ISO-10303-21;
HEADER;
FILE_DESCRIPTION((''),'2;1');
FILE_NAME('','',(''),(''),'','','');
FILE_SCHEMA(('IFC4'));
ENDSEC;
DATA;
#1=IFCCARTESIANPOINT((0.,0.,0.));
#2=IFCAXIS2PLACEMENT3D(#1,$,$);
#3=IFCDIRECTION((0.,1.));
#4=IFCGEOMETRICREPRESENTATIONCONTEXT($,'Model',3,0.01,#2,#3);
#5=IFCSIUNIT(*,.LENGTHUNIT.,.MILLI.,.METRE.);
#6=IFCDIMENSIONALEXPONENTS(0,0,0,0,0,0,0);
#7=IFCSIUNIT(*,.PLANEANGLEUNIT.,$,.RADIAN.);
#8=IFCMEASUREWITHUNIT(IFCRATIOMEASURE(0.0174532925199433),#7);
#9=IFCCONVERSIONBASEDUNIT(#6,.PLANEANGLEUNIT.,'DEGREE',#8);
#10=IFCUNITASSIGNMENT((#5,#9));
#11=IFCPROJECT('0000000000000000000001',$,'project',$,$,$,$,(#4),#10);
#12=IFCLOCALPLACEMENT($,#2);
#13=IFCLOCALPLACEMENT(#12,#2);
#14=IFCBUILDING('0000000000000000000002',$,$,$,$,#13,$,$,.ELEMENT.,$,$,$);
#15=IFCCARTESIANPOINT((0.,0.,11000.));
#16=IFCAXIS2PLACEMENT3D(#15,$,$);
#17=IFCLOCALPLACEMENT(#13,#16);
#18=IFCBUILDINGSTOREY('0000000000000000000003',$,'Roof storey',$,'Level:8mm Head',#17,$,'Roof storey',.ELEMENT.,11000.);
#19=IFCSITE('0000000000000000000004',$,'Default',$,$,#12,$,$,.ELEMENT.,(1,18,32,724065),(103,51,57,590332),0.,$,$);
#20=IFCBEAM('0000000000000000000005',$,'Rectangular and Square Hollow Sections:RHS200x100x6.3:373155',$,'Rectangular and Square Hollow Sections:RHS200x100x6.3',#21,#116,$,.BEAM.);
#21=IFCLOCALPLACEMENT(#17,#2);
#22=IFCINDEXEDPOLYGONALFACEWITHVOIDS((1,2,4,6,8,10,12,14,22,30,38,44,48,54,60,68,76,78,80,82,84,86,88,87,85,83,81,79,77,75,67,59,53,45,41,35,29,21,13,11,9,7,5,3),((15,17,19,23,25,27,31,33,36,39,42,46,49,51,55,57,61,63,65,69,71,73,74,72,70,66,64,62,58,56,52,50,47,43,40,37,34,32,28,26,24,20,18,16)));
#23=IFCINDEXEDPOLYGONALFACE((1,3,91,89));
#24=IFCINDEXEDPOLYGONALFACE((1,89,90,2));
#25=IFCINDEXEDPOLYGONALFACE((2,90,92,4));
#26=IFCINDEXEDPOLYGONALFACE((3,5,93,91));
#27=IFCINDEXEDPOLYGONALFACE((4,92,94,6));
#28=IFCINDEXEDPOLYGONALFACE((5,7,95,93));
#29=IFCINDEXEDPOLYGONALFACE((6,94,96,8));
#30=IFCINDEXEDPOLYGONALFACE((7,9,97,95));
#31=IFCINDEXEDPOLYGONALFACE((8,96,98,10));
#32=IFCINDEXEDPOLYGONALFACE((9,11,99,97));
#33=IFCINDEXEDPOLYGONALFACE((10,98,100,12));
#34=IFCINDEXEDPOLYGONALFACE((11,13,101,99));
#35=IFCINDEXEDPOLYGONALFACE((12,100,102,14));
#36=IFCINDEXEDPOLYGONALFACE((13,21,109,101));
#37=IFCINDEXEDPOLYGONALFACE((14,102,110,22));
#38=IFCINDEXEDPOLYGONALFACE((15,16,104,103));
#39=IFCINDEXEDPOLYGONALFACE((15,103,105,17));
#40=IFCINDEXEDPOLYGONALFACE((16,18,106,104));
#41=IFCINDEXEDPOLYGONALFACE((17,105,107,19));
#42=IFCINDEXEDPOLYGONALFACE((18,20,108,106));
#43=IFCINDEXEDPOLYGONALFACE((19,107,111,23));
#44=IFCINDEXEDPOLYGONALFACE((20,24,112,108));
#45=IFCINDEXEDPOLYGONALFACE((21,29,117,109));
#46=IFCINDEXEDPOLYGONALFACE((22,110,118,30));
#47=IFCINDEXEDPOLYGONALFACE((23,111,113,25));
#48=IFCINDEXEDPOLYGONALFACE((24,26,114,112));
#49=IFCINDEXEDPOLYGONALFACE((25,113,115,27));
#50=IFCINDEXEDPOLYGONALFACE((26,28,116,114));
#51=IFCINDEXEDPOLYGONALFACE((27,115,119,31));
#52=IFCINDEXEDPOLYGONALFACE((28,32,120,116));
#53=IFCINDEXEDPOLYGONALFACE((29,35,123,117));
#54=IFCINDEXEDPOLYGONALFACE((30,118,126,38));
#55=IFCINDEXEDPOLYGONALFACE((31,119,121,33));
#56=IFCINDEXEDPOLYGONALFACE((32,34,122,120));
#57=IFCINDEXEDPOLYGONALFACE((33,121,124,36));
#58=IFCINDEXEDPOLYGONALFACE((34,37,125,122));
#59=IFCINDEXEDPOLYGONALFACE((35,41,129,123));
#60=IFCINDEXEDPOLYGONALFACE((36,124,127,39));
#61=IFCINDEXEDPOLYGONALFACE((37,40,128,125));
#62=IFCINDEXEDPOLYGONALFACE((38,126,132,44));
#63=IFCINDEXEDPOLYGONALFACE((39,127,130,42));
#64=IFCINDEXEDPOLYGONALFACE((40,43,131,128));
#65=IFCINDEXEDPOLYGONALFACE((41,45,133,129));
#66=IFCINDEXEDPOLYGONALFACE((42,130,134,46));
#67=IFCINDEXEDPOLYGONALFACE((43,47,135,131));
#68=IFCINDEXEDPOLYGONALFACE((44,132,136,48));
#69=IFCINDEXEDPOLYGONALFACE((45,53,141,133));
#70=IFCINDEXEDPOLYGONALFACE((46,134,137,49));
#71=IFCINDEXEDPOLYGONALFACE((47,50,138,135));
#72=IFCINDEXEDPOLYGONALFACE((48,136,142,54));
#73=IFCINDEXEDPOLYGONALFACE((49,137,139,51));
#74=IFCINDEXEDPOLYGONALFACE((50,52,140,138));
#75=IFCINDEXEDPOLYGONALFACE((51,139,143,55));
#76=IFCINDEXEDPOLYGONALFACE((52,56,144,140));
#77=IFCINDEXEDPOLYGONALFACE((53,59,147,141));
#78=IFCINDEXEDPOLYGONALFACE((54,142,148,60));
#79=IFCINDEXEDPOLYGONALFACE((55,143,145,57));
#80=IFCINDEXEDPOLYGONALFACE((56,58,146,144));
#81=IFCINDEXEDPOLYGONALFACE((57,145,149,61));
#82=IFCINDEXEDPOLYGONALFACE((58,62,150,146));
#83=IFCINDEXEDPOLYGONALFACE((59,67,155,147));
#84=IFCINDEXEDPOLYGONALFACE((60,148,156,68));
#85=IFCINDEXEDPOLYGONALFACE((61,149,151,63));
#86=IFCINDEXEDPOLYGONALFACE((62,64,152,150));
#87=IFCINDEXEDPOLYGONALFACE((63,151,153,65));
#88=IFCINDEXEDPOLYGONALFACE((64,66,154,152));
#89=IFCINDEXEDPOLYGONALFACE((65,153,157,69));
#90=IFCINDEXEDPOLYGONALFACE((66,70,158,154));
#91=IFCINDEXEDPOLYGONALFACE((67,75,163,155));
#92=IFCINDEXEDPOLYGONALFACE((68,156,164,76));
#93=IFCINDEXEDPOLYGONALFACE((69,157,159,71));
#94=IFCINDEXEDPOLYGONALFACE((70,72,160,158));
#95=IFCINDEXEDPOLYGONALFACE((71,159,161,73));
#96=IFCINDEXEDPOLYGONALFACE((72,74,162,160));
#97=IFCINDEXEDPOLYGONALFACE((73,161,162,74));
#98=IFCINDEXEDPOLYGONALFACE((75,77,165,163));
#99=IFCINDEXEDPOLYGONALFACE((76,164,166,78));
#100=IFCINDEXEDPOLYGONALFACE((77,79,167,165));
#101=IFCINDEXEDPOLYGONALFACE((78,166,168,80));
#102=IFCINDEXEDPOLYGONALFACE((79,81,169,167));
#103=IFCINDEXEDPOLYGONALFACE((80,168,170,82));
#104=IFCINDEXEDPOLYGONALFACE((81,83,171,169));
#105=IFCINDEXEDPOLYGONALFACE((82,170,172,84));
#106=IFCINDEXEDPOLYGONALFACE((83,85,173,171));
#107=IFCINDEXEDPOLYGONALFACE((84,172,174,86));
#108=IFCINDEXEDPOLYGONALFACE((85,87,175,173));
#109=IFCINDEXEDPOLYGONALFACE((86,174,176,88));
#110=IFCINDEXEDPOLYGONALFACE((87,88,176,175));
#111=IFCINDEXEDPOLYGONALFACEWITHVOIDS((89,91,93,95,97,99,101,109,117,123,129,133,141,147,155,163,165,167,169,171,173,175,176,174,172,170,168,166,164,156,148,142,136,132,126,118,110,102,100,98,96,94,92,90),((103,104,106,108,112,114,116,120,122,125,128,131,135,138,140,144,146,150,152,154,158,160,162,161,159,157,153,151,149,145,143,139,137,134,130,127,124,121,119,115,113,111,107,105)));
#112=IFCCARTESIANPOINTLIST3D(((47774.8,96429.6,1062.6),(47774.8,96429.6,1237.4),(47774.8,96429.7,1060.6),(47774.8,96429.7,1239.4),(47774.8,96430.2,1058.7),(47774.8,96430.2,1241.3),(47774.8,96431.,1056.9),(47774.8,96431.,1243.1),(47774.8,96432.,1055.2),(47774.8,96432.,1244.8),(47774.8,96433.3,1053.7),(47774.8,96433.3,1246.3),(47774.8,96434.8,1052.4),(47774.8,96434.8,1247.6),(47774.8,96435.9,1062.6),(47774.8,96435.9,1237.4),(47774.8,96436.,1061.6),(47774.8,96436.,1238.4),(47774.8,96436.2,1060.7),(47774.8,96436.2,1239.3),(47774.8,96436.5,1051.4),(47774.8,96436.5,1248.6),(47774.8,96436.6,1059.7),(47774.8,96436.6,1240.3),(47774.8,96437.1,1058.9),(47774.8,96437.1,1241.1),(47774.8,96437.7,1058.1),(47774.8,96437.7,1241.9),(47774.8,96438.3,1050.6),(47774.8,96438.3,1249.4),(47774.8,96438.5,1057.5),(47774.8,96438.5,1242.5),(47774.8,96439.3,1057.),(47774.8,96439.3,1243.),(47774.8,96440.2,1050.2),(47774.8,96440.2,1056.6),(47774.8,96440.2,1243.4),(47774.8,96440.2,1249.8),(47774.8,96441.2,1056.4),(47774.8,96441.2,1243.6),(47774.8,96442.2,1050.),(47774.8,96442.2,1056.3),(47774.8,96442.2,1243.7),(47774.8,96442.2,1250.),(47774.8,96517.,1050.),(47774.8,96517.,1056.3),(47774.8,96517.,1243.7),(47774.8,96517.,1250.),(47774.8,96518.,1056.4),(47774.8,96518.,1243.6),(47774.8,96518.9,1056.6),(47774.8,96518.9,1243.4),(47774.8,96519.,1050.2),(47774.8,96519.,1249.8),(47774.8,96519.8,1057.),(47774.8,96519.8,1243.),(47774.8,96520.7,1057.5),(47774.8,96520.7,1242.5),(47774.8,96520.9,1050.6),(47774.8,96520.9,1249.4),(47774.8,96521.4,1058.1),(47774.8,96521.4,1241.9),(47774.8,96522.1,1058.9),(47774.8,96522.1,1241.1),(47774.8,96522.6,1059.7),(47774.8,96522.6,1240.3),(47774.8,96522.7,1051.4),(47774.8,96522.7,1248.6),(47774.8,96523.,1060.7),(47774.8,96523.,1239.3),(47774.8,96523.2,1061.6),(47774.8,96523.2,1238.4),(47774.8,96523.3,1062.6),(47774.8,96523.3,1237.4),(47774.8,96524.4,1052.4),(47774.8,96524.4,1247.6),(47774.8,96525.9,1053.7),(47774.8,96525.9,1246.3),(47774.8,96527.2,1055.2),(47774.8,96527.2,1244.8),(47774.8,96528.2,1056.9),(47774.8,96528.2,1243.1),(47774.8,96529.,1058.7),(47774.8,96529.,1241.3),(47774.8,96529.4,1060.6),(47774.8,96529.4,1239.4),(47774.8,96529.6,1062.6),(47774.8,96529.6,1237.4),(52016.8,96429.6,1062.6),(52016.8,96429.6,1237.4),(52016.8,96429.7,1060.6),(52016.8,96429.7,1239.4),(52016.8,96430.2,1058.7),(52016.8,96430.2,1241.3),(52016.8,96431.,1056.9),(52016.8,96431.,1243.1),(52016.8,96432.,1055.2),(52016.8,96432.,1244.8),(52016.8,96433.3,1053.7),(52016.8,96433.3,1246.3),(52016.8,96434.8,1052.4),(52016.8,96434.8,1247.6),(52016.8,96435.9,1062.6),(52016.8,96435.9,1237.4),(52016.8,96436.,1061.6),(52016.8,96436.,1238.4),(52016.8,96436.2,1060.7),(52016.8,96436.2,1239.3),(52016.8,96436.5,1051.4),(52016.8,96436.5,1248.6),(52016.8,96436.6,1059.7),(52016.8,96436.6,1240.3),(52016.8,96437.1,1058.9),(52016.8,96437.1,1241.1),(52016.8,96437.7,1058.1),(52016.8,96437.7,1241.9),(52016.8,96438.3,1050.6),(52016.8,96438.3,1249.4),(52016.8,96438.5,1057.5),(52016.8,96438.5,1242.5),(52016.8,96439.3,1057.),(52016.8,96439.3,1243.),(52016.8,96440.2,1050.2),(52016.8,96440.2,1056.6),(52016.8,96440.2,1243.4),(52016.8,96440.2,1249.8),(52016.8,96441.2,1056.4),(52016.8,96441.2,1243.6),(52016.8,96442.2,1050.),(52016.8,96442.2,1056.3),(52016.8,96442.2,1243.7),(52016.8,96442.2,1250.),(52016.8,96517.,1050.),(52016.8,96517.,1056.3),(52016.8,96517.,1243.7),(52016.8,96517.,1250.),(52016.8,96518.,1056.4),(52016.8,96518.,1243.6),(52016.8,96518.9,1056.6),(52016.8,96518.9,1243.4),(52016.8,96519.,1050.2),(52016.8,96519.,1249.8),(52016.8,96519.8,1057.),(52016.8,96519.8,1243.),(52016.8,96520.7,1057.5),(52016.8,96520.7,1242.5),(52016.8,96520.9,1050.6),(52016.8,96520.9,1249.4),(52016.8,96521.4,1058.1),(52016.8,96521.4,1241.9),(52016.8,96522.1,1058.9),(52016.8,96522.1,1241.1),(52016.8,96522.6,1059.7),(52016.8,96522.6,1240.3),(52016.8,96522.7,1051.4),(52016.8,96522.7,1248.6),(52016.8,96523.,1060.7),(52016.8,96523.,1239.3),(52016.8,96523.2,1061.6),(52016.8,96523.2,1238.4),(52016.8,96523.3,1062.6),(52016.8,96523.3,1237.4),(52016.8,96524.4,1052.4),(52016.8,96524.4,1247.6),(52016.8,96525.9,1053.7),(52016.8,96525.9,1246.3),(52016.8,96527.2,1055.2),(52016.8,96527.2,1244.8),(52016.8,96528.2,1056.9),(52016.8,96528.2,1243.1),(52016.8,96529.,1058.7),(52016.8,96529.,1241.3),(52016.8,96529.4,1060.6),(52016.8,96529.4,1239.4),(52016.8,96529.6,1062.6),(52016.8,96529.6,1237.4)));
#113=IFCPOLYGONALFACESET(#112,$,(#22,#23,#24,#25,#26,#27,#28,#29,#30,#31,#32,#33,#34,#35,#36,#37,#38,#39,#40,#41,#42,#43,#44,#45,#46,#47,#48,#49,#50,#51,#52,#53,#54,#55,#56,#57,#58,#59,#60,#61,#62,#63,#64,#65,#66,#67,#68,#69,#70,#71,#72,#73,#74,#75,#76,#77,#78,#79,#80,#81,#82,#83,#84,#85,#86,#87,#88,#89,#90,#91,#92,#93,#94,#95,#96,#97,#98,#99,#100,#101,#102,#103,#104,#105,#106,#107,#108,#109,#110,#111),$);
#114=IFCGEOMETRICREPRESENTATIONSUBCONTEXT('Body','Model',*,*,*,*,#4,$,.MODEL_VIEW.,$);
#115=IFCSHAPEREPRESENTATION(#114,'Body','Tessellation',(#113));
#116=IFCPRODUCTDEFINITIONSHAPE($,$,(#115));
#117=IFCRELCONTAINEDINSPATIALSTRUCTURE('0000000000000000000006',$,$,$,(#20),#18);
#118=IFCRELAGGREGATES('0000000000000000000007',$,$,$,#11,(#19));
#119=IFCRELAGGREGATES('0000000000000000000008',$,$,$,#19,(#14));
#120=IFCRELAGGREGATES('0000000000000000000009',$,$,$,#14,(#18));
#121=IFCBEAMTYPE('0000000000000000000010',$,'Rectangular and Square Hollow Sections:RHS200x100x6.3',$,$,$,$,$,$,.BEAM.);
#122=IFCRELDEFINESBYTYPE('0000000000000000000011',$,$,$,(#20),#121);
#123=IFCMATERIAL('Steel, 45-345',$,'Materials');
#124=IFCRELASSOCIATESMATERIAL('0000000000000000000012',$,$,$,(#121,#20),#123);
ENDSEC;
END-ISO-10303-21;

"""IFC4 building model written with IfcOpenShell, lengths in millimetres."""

from ifc_helpers import new_model, entity, si_unit, converted_unit, direction, frame, origin, place, context, subcontext, project, spatial, indexed_curve, outline, extrude, source, transform, mapped, material, type_object, type_shapes, element, save


model = new_model("IFC4")

# Units and contexts
model_context = context("Model", 3, precision=0.01, world=origin(), true_north=direction((0.0, 1.0)))
body_context = subcontext(model_context, "Body", "Model", "MODEL_VIEW")
ifc_project = project(units=[si_unit("LENGTHUNIT", "METRE", prefix="MILLI"), converted_unit("PLANEANGLEUNIT", "DEGREE", entity("IfcRatioMeasure", 0.0174532925199433), si_unit("PLANEANGLEUNIT", "RADIAN"), dimensions=[0, 0, 0, 0, 0, 0, 0])], contexts=[model_context])

# Site, building, storey
site_placement = place(None, origin())
site = spatial("IfcSite", under=ifc_project, at=site_placement, Name="Default", CompositionType="ELEMENT", RefLatitude=(1, 18, 32, 724065), RefLongitude=(103, 51, 57, 590332), RefElevation=0.0)
building_placement = place(site_placement, origin())
building = spatial("IfcBuilding", under=site, at=building_placement, CompositionType="ELEMENT")
storey_placement = place(building_placement, frame((0.0, 0.0, 11000.0)))
storey = spatial("IfcBuildingStorey", under=building, at=storey_placement, Name="Roof storey", ObjectType="Level:8mm Head", LongName="Roof storey", CompositionType="ELEMENT", Elevation=11000.0)

# Shared definitions
ifc_material = material(Name="Steel, 45-345", Category="Materials")

# Beam
beam_type_1 = type_object("IfcBeamType", Name="Rectangular and Square Hollow Sections:RHS200x100x6.3", PredefinedType="BEAM", material=ifc_material)
shared_shape_1 = source(origin(), body_context, "Body", "SweptSolid", [
    extrude(outline(indexed_curve([(-50.0, -87.4), (-49.8, -89.4), (-49.4, -91.3), (-48.6, -93.1), (-47.6, -94.8), (-46.3, -96.3), (-44.8, -97.6), (-43.1, -98.6), (-41.3, -99.4), (-39.4, -99.8), (-37.4, -100.0), (37.4, -100.0), (39.4, -99.8), (41.3, -99.4), (43.1, -98.6), (44.8, -97.6), (46.3, -96.3), (47.6, -94.8), (48.6, -93.1), (49.4, -91.3), (49.8, -89.4), (50.0, -87.4), (50.0, 87.4), (49.8, 89.4), (49.4, 91.3), (48.6, 93.1), (47.6, 94.8), (46.3, 96.3), (44.8, 97.6), (43.1, 98.6), (41.3, 99.4), (39.4, 99.8), (37.4, 100.0), (-37.4, 100.0), (-39.4, 99.8), (-41.3, 99.4), (-43.1, 98.6), (-44.8, 97.6), (-46.3, 96.3), (-47.6, 94.8), (-48.6, 93.1), (-49.4, 91.3), (-49.8, 89.4), (-50.0, 87.4), (-50.0, -87.4)], self_intersect=False), holes=[indexed_curve([(37.4, -93.7), (-37.4, -93.7), (-38.4, -93.6), (-39.3, -93.4), (-40.3, -93.0), (-41.1, -92.5), (-41.9, -91.9), (-42.5, -91.1), (-43.0, -90.3), (-43.4, -89.3), (-43.6, -88.4), (-43.7, -87.4), (-43.7, 87.4), (-43.6, 88.4), (-43.4, 89.3), (-43.0, 90.3), (-42.5, 91.1), (-41.9, 91.9), (-41.1, 92.5), (-40.3, 93.0), (-39.3, 93.4), (-38.4, 93.6), (-37.4, 93.7), (37.4, 93.7), (38.4, 93.6), (39.3, 93.4), (40.3, 93.0), (41.1, 92.5), (41.9, 91.9), (42.5, 91.1), (43.0, 90.3), (43.4, 89.3), (43.6, 88.4), (43.7, 87.4), (43.7, -87.4), (43.6, -88.4), (43.4, -89.3), (43.0, -90.3), (42.5, -91.1), (41.9, -91.9), (41.1, -92.5), (40.3, -93.0), (39.3, -93.4), (38.4, -93.6), (37.4, -93.7)], self_intersect=False)]), frame((-2114.5, 0.0, 0.0), z_axis=(1.0, 0.0, 0.0), x_axis=(0.0, -1.0, 0.0)), (0.0, 0.0, 1.0), 4242.0),
])
type_shapes(beam_type_1, [shared_shape_1])
beam_1_placement = place(storey_placement, frame((49889.3, 96479.6, 1150.0)))
element("IfcBeam", 1, at=beam_1_placement, inside=storey, type_object=beam_type_1, material=ifc_material, Name="Rectangular and Square Hollow Sections:RHS200x100x6.3:373155", ObjectType="Rectangular and Square Hollow Sections:RHS200x100x6.3", PredefinedType="BEAM", context=body_context, shape_type="MappedRepresentation", body=[
    mapped(shared_shape_1, transform((0.0, 0.0, 0.0), scale=1.0)),
])

save(model, "model.ifc")
